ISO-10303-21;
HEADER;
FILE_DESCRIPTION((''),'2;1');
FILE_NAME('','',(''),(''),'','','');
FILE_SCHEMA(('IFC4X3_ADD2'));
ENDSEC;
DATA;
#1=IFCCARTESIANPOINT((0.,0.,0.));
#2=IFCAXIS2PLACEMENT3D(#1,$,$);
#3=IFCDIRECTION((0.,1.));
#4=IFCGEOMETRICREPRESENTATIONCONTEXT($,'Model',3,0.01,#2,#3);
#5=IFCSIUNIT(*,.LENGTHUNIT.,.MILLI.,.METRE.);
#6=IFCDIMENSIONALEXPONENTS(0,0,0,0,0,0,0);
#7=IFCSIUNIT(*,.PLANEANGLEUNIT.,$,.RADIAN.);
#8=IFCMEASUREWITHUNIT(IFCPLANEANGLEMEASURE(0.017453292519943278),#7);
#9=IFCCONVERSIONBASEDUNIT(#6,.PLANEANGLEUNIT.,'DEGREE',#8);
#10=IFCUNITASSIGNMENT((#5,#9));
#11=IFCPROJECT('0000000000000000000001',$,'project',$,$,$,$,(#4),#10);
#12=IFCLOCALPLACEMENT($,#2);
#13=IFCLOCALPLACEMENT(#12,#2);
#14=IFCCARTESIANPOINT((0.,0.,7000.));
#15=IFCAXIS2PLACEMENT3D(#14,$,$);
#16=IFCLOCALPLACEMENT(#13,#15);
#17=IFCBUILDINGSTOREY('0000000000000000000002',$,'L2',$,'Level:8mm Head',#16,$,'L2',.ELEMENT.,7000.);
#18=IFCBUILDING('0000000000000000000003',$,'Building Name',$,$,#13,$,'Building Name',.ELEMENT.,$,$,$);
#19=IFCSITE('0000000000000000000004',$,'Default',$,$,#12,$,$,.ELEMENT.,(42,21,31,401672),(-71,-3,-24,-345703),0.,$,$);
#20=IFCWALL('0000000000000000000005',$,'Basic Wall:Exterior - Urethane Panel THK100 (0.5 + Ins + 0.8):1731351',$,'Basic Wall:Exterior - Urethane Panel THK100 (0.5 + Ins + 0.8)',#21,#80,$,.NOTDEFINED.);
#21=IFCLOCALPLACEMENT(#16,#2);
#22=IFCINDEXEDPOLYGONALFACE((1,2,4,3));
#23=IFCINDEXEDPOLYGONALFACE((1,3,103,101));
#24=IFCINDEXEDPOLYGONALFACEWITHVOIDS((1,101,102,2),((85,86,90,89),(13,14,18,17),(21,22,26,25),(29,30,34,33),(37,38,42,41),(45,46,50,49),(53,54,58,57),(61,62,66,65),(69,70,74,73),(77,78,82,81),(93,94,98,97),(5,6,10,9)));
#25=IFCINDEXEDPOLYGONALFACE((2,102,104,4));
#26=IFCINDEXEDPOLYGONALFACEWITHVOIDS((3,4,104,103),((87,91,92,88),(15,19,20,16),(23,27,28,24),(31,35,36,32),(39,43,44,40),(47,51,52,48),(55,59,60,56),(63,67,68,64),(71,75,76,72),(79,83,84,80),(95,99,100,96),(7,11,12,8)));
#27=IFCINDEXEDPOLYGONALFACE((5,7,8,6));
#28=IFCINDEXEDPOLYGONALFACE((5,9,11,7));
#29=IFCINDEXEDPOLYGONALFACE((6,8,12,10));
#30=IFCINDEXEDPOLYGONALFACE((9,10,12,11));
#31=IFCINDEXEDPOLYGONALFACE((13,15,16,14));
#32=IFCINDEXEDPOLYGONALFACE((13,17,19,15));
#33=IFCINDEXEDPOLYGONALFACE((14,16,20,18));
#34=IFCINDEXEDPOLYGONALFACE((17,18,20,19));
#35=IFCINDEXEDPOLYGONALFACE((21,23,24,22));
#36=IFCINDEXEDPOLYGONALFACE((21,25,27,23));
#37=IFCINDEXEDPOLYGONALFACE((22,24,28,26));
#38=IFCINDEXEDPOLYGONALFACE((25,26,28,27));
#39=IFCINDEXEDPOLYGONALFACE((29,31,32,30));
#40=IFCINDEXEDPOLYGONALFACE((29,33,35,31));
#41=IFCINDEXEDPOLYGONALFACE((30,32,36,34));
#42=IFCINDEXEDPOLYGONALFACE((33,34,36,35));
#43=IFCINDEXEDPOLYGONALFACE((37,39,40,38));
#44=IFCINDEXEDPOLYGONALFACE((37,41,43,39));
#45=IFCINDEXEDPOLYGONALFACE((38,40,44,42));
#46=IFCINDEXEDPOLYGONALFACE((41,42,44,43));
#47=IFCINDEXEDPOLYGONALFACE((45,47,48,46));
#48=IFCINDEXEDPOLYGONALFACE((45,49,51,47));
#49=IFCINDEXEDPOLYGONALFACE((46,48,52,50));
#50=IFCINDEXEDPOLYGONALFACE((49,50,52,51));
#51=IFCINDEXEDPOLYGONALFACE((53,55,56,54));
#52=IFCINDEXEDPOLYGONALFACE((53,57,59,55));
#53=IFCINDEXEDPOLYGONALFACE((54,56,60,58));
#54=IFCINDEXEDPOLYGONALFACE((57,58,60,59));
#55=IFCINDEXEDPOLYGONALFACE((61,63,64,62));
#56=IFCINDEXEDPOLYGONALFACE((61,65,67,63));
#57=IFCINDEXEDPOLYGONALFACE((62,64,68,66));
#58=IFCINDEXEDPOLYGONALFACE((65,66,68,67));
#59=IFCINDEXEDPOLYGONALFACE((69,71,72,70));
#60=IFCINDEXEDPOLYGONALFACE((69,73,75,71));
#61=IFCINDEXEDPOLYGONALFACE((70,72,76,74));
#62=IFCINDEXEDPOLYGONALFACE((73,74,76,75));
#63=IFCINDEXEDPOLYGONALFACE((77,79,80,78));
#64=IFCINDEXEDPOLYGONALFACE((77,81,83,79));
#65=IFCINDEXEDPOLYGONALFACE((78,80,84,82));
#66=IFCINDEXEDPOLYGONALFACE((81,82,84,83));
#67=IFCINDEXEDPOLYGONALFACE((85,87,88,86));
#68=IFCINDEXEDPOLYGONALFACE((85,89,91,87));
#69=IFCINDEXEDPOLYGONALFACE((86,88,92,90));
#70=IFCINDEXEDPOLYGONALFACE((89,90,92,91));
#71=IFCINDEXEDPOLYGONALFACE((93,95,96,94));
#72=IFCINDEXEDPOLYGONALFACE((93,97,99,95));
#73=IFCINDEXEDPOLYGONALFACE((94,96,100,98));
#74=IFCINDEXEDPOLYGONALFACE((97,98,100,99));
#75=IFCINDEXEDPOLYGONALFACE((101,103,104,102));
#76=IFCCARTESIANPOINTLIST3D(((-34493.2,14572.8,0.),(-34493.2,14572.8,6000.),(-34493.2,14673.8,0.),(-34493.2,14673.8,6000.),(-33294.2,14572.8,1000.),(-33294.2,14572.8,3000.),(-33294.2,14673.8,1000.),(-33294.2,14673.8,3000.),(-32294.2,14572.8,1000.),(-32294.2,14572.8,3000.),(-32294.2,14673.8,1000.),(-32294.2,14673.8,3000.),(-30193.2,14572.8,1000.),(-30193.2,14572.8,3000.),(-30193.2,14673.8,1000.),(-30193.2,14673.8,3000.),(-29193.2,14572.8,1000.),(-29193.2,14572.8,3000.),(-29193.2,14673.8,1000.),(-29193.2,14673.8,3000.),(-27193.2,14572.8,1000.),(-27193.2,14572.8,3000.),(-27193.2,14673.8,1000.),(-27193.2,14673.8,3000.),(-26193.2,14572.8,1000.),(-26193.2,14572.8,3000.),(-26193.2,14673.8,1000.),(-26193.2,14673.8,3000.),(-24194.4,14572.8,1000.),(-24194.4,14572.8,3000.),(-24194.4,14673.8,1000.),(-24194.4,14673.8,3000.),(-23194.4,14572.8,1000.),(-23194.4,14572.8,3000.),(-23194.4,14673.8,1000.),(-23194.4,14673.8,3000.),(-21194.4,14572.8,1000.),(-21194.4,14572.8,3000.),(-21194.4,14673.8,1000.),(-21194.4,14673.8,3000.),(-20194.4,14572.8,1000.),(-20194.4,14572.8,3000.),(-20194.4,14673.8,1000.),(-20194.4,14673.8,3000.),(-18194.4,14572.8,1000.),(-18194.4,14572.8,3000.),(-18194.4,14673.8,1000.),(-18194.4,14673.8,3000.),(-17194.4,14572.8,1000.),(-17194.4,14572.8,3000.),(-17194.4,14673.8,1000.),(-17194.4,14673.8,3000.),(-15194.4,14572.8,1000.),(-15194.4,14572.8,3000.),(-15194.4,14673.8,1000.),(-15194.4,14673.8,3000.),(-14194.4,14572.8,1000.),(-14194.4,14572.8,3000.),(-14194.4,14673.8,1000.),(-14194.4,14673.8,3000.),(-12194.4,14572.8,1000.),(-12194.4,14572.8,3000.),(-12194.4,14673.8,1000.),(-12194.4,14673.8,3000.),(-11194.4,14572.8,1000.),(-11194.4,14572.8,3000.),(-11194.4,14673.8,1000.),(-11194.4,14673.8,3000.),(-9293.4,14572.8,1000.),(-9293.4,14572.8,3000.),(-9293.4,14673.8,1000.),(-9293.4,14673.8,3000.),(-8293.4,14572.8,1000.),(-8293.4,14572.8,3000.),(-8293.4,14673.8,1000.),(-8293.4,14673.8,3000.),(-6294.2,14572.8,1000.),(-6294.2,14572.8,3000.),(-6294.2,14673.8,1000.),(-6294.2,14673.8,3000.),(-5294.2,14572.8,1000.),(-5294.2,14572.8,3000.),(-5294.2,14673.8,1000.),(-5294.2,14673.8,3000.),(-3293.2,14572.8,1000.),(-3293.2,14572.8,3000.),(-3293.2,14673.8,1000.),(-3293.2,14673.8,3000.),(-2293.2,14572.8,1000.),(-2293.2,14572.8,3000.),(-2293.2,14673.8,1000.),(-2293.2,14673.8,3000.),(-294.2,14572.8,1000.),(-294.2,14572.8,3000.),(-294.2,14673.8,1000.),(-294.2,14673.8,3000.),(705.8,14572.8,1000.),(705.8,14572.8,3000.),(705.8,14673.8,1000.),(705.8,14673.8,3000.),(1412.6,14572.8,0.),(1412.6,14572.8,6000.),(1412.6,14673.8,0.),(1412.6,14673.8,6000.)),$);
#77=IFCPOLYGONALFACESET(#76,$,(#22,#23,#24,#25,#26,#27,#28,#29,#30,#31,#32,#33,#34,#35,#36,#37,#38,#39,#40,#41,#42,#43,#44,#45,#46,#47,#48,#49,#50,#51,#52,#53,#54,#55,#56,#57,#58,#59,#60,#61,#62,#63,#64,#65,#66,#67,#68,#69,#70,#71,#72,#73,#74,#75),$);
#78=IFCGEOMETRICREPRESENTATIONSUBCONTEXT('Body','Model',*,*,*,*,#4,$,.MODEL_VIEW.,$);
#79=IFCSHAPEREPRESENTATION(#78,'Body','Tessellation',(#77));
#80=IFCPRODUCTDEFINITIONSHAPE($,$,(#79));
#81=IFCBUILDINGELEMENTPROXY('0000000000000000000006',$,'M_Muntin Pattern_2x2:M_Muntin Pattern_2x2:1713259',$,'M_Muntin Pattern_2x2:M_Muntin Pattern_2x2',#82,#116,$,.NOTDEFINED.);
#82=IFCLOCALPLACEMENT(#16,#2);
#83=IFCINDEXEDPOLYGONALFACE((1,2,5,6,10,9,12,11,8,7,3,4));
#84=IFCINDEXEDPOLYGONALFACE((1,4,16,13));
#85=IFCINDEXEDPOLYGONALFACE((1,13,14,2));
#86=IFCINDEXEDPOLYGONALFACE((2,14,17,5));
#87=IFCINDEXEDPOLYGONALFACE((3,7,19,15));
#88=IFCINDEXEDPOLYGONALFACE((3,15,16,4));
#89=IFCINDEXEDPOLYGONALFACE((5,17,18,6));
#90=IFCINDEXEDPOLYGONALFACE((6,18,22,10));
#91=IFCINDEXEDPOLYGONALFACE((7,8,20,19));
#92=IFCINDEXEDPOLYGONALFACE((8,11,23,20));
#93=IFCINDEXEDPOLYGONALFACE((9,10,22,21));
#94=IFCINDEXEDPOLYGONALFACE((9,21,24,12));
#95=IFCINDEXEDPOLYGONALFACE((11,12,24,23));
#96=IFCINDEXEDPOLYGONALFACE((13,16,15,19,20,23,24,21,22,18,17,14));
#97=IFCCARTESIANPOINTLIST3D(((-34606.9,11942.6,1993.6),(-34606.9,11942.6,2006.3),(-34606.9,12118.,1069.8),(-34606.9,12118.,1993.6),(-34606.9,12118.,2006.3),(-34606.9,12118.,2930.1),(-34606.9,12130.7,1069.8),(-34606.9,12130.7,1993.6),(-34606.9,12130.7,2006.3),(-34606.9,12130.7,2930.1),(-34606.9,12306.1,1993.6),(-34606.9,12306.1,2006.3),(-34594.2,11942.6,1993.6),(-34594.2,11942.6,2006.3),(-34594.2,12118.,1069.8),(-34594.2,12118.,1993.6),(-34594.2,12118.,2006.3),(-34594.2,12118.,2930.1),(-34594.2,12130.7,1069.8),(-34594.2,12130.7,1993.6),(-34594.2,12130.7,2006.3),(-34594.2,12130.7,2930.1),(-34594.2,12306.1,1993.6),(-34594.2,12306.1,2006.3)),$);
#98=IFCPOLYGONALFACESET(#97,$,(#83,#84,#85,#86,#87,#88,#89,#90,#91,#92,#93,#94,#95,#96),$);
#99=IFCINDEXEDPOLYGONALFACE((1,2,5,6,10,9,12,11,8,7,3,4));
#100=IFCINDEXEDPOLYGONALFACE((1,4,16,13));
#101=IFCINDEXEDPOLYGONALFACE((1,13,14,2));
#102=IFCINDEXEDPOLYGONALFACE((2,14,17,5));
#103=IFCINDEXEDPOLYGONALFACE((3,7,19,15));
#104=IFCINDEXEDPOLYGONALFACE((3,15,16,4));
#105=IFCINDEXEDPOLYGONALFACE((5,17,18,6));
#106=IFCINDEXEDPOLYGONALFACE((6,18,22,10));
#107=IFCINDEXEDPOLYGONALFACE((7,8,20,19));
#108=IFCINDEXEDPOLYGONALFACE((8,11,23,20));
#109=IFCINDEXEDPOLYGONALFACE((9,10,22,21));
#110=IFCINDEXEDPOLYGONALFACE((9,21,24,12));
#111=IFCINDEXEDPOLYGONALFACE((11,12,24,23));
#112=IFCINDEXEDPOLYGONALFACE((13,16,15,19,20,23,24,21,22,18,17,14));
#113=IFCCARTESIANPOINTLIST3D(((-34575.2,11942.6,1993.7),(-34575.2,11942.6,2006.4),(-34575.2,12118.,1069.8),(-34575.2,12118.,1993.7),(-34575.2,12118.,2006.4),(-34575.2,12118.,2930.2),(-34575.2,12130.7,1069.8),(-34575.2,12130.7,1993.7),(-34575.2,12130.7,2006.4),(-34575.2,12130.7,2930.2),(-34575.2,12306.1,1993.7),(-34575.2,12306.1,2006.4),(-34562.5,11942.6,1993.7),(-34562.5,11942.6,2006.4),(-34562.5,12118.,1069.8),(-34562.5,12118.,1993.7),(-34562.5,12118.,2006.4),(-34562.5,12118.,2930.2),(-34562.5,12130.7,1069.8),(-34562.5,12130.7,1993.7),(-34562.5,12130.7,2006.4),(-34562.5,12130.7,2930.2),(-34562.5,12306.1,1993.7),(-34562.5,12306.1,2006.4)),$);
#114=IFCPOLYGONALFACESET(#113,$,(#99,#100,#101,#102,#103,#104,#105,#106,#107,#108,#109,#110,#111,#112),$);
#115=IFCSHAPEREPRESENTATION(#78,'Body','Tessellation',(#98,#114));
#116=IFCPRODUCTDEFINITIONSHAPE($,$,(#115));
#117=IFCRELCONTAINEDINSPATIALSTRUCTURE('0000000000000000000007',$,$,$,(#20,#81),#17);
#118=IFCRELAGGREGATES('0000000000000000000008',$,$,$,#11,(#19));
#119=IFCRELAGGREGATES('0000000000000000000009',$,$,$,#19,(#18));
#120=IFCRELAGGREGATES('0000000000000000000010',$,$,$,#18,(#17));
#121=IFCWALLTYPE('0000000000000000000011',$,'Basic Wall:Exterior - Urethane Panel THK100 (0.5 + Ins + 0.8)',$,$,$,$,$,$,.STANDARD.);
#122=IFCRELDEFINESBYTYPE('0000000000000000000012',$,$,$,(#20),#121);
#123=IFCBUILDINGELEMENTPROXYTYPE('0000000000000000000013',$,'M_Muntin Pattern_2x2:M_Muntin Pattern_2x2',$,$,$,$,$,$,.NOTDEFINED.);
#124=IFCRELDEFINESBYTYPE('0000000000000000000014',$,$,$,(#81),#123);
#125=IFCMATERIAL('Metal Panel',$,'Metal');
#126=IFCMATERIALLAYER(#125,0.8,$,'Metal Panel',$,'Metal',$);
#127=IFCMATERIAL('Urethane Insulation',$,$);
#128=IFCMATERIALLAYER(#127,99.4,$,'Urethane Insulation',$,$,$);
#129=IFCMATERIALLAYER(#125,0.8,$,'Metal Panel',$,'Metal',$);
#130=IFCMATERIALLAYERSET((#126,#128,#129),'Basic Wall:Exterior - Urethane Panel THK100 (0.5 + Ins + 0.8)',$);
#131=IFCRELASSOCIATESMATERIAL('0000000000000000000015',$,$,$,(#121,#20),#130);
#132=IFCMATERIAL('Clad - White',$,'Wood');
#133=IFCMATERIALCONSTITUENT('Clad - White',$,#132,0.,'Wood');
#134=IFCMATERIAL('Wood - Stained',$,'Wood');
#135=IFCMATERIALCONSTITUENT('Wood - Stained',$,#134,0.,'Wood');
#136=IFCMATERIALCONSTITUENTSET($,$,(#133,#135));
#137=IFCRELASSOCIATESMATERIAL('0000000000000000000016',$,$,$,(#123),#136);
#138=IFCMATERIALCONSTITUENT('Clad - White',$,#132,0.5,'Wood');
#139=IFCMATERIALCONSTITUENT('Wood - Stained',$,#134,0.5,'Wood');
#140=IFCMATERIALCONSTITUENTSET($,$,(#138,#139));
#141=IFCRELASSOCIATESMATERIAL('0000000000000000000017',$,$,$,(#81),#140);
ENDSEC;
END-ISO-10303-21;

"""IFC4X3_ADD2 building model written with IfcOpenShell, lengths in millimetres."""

from ifc_helpers import new_model, entity, si_unit, converted_unit, direction, frame, frame_2d, origin, place, context, subcontext, project, spatial, polyline, rectangle, outline, extrude, source, transform, mapped, material, layer, layer_set, constituent, constituent_set, type_object, type_shapes, element, save


model = new_model("IFC4X3_ADD2")

# Units and contexts
model_context = context("Model", 3, precision=0.01, world=origin(), true_north=direction((0.0, 1.0)))
body_context = subcontext(model_context, "Body", "Model", "MODEL_VIEW")
ifc_project = project(units=[si_unit("LENGTHUNIT", "METRE", prefix="MILLI"), converted_unit("PLANEANGLEUNIT", "DEGREE", entity("IfcPlaneAngleMeasure", 0.017453292519943278), si_unit("PLANEANGLEUNIT", "RADIAN"), dimensions=[0, 0, 0, 0, 0, 0, 0])], contexts=[model_context])

# Site, building, storey
site_placement = place(None, origin())
site = spatial("IfcSite", under=ifc_project, at=site_placement, Name="Default", CompositionType="ELEMENT", RefLatitude=(42, 21, 31, 401672), RefLongitude=(-71, -3, -24, -345703), RefElevation=0.0)
building_placement = place(site_placement, origin())
building = spatial("IfcBuilding", under=site, at=building_placement, Name="Building Name", LongName="Building Name", CompositionType="ELEMENT")
storey_placement = place(building_placement, frame((0.0, 0.0, 7000.0)))
storey = spatial("IfcBuildingStorey", under=building, at=storey_placement, Name="L2", ObjectType="Level:8mm Head", LongName="L2", CompositionType="ELEMENT", Elevation=7000.0)

# Wall, openings
ifc_material_1 = material(Name="Metal Panel", Category="Metal")
ifc_layer_1 = layer(ifc_material_1, 0.8, Name="Metal Panel", Category="Metal")
ifc_material_2 = material(Name="Urethane Insulation")
ifc_layer_2 = layer(ifc_material_2, 99.4, Name="Urethane Insulation")
ifc_layer_3 = layer(ifc_material_1, 0.8, Name="Metal Panel", Category="Metal")
ifc_layer_set = layer_set([ifc_layer_1, ifc_layer_2, ifc_layer_3], Name="Basic Wall:Exterior - Urethane Panel THK100 (0.5 + Ins + 0.8)")
wall_type = type_object("IfcWallType", Name="Basic Wall:Exterior - Urethane Panel THK100 (0.5 + Ins + 0.8)", PredefinedType="STANDARD", material=ifc_layer_set)
wall_placement = place(storey_placement, frame((-34493.2, 14623.3, 0.0)))
wall = element("IfcWall", 1, at=wall_placement, inside=storey, type_object=wall_type, material=ifc_layer_set, Name="Basic Wall:Exterior - Urethane Panel THK100 (0.5 + Ins + 0.8):1731351", ObjectType="Basic Wall:Exterior - Urethane Panel THK100 (0.5 + Ins + 0.8)", PredefinedType="NOTDEFINED", context=body_context, shape_type="SweptSolid", body=[
    extrude(rectangle(XDim=35905.8, YDim=101.0, at=frame_2d((17952.9, 0.0), x_axis=(-1.0, 0.0))), origin(), (0.0, 0.0, 1.0), 6000.0),
])
opening_1_placement = place(wall_placement, frame((34199.0, -50.5, 1000.0)))
element("IfcOpeningElement", 2, at=opening_1_placement, cuts=wall, PredefinedType="OPENING", context=body_context, shape_type="SweptSolid", body=[
    extrude(rectangle(XDim=2000.0, YDim=1000.0, at=frame_2d((1000.0, 500.0), x_axis=(-1.0, 0.0))), frame((0.0, 0.0, 0.0), z_axis=(0.0, 1.0, 0.0), x_axis=(0.0, 0.0, 1.0)), (0.0, 0.0, 1.0), 101.0),
])
opening_2_placement = place(wall_placement, frame((31200.0, -50.5, 1000.0)))
element("IfcOpeningElement", 3, at=opening_2_placement, cuts=wall, PredefinedType="OPENING", context=body_context, shape_type="SweptSolid", body=[
    extrude(rectangle(XDim=2000.0, YDim=1000.0, at=frame_2d((1000.0, 500.0), x_axis=(-1.0, 0.0))), frame((0.0, 0.0, 0.0), z_axis=(0.0, 1.0, 0.0), x_axis=(0.0, 0.0, 1.0)), (0.0, 0.0, 1.0), 101.0),
])
opening_3_placement = place(wall_placement, frame((28199.0, -50.5, 1000.0)))
element("IfcOpeningElement", 4, at=opening_3_placement, cuts=wall, PredefinedType="OPENING", context=body_context, shape_type="SweptSolid", body=[
    extrude(rectangle(XDim=2000.0, YDim=1000.0, at=frame_2d((1000.0, 500.0), x_axis=(-1.0, 0.0))), frame((0.0, 0.0, 0.0), z_axis=(0.0, 1.0, 0.0), x_axis=(0.0, 0.0, 1.0)), (0.0, 0.0, 1.0), 101.0),
])
opening_4_placement = place(wall_placement, frame((25199.8, -50.5, 1000.0)))
element("IfcOpeningElement", 5, at=opening_4_placement, cuts=wall, PredefinedType="OPENING", context=body_context, shape_type="SweptSolid", body=[
    extrude(rectangle(XDim=2000.0, YDim=1000.0, at=frame_2d((1000.0, 500.0), x_axis=(-1.0, 0.0))), frame((0.0, 0.0, 0.0), z_axis=(0.0, 1.0, 0.0), x_axis=(0.0, 0.0, 1.0)), (0.0, 0.0, 1.0), 101.0),
])
opening_5_placement = place(wall_placement, frame((22298.8, -50.5, 1000.0)))
element("IfcOpeningElement", 6, at=opening_5_placement, cuts=wall, PredefinedType="OPENING", context=body_context, shape_type="SweptSolid", body=[
    extrude(rectangle(XDim=2000.0, YDim=1000.0, at=frame_2d((1000.0, 500.0), x_axis=(-1.0, 0.0))), frame((0.0, 0.0, 0.0), z_axis=(0.0, 1.0, 0.0), x_axis=(0.0, 0.0, 1.0)), (0.0, 0.0, 1.0), 101.0),
])
opening_6_placement = place(wall_placement, frame((19298.8, -50.5, 1000.0)))
element("IfcOpeningElement", 7, at=opening_6_placement, cuts=wall, PredefinedType="OPENING", context=body_context, shape_type="SweptSolid", body=[
    extrude(rectangle(XDim=2000.0, YDim=1000.0, at=frame_2d((1000.0, 500.0), x_axis=(-1.0, 0.0))), frame((0.0, 0.0, 0.0), z_axis=(0.0, 1.0, 0.0), x_axis=(0.0, 0.0, 1.0)), (0.0, 0.0, 1.0), 101.0),
])
opening_7_placement = place(wall_placement, frame((16298.8, -50.5, 1000.0)))
element("IfcOpeningElement", 8, at=opening_7_placement, cuts=wall, PredefinedType="OPENING", context=body_context, shape_type="SweptSolid", body=[
    extrude(rectangle(XDim=2000.0, YDim=1000.0, at=frame_2d((1000.0, 500.0), x_axis=(-1.0, 0.0))), frame((0.0, 0.0, 0.0), z_axis=(0.0, 1.0, 0.0), x_axis=(0.0, 0.0, 1.0)), (0.0, 0.0, 1.0), 101.0),
])
opening_8_placement = place(wall_placement, frame((13298.8, -50.5, 1000.0)))
element("IfcOpeningElement", 9, at=opening_8_placement, cuts=wall, PredefinedType="OPENING", context=body_context, shape_type="SweptSolid", body=[
    extrude(rectangle(XDim=2000.0, YDim=1000.0, at=frame_2d((1000.0, 500.0), x_axis=(-1.0, 0.0))), frame((0.0, 0.0, 0.0), z_axis=(0.0, 1.0, 0.0), x_axis=(0.0, 0.0, 1.0)), (0.0, 0.0, 1.0), 101.0),
])
opening_9_placement = place(wall_placement, frame((10298.8, -50.5, 1000.0)))
element("IfcOpeningElement", 10, at=opening_9_placement, cuts=wall, PredefinedType="OPENING", context=body_context, shape_type="SweptSolid", body=[
    extrude(rectangle(XDim=2000.0, YDim=1000.0, at=frame_2d((1000.0, 500.0), x_axis=(-1.0, 0.0))), frame((0.0, 0.0, 0.0), z_axis=(0.0, 1.0, 0.0), x_axis=(0.0, 0.0, 1.0)), (0.0, 0.0, 1.0), 101.0),
])
opening_10_placement = place(wall_placement, frame((7300.0, -50.5, 1000.0)))
element("IfcOpeningElement", 11, at=opening_10_placement, cuts=wall, PredefinedType="OPENING", context=body_context, shape_type="SweptSolid", body=[
    extrude(rectangle(XDim=2000.0, YDim=1000.0, at=frame_2d((1000.0, 500.0), x_axis=(-1.0, 0.0))), frame((0.0, 0.0, 0.0), z_axis=(0.0, 1.0, 0.0), x_axis=(0.0, 0.0, 1.0)), (0.0, 0.0, 1.0), 101.0),
])
opening_11_placement = place(wall_placement, frame((4300.0, -50.5, 1000.0)))
element("IfcOpeningElement", 12, at=opening_11_placement, cuts=wall, PredefinedType="OPENING", context=body_context, shape_type="SweptSolid", body=[
    extrude(rectangle(XDim=2000.0, YDim=1000.0, at=frame_2d((1000.0, 500.0), x_axis=(-1.0, 0.0))), frame((0.0, 0.0, 0.0), z_axis=(0.0, 1.0, 0.0), x_axis=(0.0, 0.0, 1.0)), (0.0, 0.0, 1.0), 101.0),
])
opening_12_placement = place(wall_placement, frame((1199.0, -50.5, 1000.0)))
element("IfcOpeningElement", 13, at=opening_12_placement, cuts=wall, PredefinedType="OPENING", context=body_context, shape_type="SweptSolid", body=[
    extrude(rectangle(XDim=2000.0, YDim=1000.0, at=frame_2d((1000.0, 500.0), x_axis=(-1.0, 0.0))), frame((0.0, 0.0, 0.0), z_axis=(0.0, 1.0, 0.0), x_axis=(0.0, 0.0, 1.0)), (0.0, 0.0, 1.0), 101.0),
])

# Building element proxy
ifc_material_3 = material(Name="Clad - White", Category="Wood")
ifc_constituent_1 = constituent(ifc_material_3, Name="Clad - White", Category="Wood", fraction=0.5)
ifc_material_4 = material(Name="Wood - Stained", Category="Wood")
ifc_constituent_2 = constituent(ifc_material_4, Name="Wood - Stained", Category="Wood", fraction=0.5)
ifc_constituent_set_1 = constituent_set(constituents=[ifc_constituent_1, ifc_constituent_2])
ifc_constituent_3 = constituent(ifc_material_3, Name="Clad - White", Category="Wood", fraction=0.0)
ifc_constituent_4 = constituent(ifc_material_4, Name="Wood - Stained", Category="Wood", fraction=0.0)
ifc_constituent_set_2 = constituent_set(constituents=[ifc_constituent_3, ifc_constituent_4])
building_element_proxy_type_1 = type_object("IfcBuildingElementProxyType", Name="M_Muntin Pattern_2x2:M_Muntin Pattern_2x2", PredefinedType="NOTDEFINED", material=ifc_constituent_set_2)
shared_shape_1 = source(origin(), body_context, "Body", "SweptSolid", [
    extrude(outline(polyline([(6.4, -6.4), (930.1, -6.4), (930.1, 6.3), (6.4, 6.3), (6.4, 181.7), (-6.3, 181.7), (-6.3, 6.3), (-930.2, 6.3), (-930.2, -6.4), (-6.3, -6.4), (-6.3, -181.7), (6.4, -181.7), (6.4, -6.4)])), frame((0.0, 9.5, 930.1), z_axis=(0.0, 1.0, 0.0), x_axis=(0.0, 0.0, 1.0)), (0.0, 0.0, 1.0), 12.7),
    extrude(outline(polyline([(6.4, -6.4), (930.2, -6.4), (930.2, 6.3), (6.4, 6.3), (6.4, 181.7), (-6.3, 181.7), (-6.3, 6.3), (-930.2, 6.3), (-930.2, -6.4), (-6.3, -6.4), (-6.3, -181.7), (6.4, -181.7), (6.4, -6.4)])), frame((0.0, -22.2, 930.2), z_axis=(0.0, 1.0, 0.0), x_axis=(0.0, 0.0, 1.0)), (0.0, 0.0, 1.0), 12.7),
])
type_shapes(building_element_proxy_type_1, [shared_shape_1])
proxy_1_placement = place(storey_placement, frame((-34584.7, 12124.4, 1069.8), z_axis=(0.0, 0.0, 1.0), x_axis=(0.0, 1.0, 0.0)))
element("IfcBuildingElementProxy", 14, at=proxy_1_placement, inside=storey, type_object=building_element_proxy_type_1, material=ifc_constituent_set_1, Name="M_Muntin Pattern_2x2:M_Muntin Pattern_2x2:1713259", ObjectType="M_Muntin Pattern_2x2:M_Muntin Pattern_2x2", PredefinedType="NOTDEFINED", context=body_context, shape_type="MappedRepresentation", body=[
    mapped(shared_shape_1, transform((0.0, 0.0, 0.0), scale=1.0)),
])

save(model, "model.ifc")
